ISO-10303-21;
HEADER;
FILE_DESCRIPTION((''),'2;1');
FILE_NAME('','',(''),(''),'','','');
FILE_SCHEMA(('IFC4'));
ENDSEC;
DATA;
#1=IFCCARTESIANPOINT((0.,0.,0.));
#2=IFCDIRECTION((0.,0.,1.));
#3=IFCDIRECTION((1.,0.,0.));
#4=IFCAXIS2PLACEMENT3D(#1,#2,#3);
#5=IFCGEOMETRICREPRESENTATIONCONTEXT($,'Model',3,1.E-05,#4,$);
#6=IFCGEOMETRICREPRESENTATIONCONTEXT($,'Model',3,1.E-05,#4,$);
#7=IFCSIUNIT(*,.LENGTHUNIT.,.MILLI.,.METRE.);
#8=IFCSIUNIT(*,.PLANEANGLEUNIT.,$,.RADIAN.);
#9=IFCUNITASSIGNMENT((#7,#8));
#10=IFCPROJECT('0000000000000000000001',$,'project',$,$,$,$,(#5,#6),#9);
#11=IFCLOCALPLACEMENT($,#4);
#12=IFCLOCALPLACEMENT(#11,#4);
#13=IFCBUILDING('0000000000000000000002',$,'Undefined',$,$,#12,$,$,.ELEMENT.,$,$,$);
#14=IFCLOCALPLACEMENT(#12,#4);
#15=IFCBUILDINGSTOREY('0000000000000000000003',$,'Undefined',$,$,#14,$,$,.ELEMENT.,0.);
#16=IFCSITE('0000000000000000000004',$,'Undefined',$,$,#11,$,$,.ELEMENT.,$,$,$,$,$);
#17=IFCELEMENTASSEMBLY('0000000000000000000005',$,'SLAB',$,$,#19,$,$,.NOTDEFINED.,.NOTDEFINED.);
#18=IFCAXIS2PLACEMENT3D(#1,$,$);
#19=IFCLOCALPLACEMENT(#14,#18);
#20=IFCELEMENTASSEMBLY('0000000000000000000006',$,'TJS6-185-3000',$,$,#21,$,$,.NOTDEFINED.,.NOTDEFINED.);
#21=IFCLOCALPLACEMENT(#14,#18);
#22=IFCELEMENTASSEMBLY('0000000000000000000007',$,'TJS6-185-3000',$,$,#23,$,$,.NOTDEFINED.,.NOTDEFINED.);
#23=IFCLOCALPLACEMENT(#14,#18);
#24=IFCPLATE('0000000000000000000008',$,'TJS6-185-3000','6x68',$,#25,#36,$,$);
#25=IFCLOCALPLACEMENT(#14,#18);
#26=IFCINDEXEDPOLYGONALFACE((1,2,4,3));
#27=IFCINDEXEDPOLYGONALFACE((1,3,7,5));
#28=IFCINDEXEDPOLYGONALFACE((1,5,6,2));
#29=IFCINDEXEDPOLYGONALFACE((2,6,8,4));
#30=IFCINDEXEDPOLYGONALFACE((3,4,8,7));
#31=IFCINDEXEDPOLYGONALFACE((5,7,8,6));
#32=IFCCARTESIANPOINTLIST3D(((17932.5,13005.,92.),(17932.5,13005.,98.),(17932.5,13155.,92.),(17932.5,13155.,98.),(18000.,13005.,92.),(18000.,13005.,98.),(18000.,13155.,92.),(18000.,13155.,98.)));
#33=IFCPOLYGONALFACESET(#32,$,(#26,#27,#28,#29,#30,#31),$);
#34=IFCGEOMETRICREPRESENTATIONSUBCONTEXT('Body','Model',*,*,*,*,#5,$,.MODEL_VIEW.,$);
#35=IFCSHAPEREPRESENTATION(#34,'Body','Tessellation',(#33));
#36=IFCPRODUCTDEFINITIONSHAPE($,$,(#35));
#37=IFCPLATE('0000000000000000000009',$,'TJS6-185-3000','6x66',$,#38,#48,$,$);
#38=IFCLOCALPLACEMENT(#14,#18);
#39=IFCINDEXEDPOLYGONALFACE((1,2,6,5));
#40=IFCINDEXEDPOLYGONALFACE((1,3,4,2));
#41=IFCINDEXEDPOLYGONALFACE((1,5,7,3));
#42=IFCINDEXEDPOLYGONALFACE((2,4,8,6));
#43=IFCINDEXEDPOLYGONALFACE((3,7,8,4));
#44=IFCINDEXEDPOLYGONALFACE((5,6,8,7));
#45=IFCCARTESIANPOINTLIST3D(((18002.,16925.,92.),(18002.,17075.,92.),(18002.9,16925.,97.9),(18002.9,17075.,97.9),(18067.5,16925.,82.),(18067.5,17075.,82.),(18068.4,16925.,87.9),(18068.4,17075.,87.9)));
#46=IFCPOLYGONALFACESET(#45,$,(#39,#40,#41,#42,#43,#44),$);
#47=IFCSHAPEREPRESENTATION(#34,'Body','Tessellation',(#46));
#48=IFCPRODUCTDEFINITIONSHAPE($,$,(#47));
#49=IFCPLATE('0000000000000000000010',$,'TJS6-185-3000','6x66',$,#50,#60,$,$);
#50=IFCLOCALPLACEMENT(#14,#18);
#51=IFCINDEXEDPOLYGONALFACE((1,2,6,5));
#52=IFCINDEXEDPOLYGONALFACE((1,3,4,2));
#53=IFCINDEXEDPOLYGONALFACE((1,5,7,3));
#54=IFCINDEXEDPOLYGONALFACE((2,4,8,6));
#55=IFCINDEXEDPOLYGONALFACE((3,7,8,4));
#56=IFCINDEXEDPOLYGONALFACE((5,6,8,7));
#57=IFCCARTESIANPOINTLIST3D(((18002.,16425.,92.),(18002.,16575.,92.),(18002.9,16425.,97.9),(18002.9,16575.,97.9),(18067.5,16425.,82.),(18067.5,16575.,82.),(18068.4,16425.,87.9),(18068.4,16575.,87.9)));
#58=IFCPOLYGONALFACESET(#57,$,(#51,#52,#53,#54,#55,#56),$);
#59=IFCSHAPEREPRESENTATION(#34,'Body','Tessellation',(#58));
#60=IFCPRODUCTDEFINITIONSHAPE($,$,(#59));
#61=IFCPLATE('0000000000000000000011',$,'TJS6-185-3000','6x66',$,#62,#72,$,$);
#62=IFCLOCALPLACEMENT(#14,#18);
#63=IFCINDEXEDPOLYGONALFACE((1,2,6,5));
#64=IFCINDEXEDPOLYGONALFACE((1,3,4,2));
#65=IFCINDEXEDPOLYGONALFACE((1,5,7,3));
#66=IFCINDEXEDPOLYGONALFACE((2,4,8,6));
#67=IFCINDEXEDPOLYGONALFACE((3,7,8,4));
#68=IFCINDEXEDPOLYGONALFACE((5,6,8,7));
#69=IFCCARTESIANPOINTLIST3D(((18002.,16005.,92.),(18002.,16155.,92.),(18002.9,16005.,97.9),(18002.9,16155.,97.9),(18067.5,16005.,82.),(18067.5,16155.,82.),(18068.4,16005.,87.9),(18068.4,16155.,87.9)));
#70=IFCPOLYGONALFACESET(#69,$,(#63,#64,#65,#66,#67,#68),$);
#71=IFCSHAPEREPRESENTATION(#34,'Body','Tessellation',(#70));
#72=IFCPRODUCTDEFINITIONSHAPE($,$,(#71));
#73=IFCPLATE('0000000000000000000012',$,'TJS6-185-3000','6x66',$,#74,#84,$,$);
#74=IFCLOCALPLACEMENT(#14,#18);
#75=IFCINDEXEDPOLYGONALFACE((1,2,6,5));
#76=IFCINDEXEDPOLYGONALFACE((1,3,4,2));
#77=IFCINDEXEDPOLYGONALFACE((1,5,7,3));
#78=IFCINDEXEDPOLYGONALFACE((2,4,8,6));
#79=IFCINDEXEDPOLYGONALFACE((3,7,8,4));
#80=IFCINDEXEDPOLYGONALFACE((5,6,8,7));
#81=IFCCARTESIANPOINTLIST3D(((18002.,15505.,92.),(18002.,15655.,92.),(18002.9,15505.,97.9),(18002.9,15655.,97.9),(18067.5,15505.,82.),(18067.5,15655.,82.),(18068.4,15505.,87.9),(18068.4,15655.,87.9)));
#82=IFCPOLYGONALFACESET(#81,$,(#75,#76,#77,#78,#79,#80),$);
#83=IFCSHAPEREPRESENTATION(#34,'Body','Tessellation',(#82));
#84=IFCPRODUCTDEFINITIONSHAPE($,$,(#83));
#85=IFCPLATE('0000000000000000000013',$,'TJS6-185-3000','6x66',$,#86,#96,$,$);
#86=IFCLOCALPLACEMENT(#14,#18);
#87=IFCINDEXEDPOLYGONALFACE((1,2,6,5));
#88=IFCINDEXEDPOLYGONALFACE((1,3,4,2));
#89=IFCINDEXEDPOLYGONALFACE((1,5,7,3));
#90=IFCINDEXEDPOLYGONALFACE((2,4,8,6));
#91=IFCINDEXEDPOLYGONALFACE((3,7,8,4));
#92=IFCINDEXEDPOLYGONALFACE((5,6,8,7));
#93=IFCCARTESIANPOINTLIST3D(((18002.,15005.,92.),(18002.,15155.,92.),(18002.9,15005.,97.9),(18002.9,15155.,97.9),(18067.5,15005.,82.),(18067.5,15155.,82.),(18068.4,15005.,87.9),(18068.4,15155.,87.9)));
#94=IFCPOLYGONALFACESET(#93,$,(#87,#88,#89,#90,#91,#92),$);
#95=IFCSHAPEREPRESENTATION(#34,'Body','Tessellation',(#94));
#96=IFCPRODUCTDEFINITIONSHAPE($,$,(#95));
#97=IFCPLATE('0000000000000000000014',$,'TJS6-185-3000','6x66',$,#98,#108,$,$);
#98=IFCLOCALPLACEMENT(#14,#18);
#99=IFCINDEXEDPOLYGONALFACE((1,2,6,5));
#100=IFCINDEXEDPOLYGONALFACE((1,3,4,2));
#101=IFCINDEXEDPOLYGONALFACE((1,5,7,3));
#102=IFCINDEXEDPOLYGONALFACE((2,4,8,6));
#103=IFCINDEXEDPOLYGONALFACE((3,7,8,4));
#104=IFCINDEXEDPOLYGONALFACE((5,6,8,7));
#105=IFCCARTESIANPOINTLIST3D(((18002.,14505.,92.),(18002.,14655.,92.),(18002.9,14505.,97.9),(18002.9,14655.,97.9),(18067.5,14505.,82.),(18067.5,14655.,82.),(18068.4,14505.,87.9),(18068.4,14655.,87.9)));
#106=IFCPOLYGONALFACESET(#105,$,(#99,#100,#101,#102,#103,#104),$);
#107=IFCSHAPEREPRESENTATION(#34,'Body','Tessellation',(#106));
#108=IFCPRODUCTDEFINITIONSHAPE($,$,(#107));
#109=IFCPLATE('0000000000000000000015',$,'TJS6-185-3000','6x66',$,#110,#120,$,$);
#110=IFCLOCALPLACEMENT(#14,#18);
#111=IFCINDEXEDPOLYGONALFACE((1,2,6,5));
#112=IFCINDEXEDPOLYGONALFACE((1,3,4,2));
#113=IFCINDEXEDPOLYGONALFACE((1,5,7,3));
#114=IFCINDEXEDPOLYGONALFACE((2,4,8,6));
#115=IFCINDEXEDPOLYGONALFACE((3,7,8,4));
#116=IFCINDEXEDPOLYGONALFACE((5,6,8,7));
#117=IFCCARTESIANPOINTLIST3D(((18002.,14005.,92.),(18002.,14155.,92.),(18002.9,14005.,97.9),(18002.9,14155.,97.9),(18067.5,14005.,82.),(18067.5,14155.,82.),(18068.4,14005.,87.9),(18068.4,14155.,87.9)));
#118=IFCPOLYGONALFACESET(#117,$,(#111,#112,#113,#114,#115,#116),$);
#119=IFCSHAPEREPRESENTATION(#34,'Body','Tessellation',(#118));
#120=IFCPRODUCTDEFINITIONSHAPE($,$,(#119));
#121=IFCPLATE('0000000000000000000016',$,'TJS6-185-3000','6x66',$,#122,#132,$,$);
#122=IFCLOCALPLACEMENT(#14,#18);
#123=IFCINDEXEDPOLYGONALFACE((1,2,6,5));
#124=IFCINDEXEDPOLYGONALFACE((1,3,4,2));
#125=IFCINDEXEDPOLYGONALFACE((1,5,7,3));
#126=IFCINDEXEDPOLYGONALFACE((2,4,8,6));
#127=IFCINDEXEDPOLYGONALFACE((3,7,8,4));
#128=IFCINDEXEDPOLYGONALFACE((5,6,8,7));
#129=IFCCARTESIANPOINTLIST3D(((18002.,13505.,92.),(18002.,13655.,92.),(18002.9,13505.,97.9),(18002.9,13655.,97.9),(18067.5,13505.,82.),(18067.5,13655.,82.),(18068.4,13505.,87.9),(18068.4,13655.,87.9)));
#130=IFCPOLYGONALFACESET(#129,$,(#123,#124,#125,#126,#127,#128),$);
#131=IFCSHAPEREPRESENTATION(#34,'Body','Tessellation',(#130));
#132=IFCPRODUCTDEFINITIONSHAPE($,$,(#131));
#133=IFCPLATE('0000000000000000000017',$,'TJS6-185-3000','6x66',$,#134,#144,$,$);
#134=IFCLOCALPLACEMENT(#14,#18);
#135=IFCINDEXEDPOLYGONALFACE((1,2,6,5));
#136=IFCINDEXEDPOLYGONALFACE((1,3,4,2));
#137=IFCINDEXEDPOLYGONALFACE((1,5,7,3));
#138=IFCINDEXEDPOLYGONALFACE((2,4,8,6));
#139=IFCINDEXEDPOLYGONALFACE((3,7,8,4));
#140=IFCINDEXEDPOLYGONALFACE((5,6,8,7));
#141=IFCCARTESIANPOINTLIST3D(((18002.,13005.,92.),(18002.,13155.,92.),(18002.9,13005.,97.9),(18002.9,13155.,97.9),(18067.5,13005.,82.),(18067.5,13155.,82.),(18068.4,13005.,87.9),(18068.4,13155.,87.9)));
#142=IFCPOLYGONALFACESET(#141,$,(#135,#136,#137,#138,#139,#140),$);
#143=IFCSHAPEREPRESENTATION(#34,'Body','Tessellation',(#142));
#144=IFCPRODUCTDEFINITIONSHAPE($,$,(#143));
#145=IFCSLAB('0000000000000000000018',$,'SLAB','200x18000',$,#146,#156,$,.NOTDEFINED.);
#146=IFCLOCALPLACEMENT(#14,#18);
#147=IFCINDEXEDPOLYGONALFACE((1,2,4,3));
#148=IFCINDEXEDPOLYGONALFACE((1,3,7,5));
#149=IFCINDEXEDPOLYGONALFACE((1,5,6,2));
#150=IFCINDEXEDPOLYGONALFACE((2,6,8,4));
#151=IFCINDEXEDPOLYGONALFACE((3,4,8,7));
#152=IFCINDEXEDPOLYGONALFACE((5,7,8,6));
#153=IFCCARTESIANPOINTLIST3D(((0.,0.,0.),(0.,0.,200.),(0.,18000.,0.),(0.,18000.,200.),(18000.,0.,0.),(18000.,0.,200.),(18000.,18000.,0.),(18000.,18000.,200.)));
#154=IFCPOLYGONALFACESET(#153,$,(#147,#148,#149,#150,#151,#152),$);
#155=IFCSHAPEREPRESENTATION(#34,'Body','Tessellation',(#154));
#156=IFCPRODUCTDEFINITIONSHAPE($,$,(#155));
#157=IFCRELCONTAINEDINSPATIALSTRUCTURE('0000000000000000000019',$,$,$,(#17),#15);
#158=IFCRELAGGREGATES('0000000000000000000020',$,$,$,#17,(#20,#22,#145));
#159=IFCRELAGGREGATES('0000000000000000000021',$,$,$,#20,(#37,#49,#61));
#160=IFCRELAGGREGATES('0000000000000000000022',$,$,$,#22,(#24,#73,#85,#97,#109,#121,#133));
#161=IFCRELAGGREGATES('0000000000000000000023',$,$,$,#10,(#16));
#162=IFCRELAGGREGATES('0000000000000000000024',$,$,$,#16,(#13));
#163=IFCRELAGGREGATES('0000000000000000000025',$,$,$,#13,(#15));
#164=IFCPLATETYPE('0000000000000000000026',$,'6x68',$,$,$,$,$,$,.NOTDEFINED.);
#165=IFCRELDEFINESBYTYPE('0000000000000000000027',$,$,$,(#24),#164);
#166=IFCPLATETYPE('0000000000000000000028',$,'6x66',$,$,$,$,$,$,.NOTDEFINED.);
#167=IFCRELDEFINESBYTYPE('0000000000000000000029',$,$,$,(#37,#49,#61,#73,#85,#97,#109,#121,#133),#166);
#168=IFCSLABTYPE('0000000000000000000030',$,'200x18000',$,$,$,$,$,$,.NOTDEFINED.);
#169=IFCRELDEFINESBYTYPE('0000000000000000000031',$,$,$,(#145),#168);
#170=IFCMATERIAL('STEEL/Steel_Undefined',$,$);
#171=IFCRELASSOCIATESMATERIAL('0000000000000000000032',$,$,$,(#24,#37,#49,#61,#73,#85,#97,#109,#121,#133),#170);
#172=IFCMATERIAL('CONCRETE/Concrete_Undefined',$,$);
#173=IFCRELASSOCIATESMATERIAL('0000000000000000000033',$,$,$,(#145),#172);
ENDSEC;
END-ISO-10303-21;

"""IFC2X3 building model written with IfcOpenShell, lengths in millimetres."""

from ifc_helpers import new_model, si_unit, frame, origin_with_axes, place, context, subcontext, project, spatial, polyline, outline, extrude, material, type_object, element, aggregate, save


model = new_model("IFC2X3")

# Units and contexts
model_context_1 = context("Model", 3, precision=1e-05, world=origin_with_axes())
model_context_2 = context("Model", 3, precision=1e-05, world=origin_with_axes())
body_context = subcontext(model_context_1, "Body", "Model", "MODEL_VIEW")
ifc_project = project(units=[si_unit("LENGTHUNIT", "METRE", prefix="MILLI"), si_unit("PLANEANGLEUNIT", "RADIAN")], contexts=[model_context_1, model_context_2])

# Site, building, storey
site_placement = place(None, origin_with_axes())
site = spatial("IfcSite", under=ifc_project, at=site_placement, Name="Undefined", CompositionType="ELEMENT")
building_placement = place(site_placement, origin_with_axes())
building = spatial("IfcBuilding", under=site, at=building_placement, Name="Undefined", CompositionType="ELEMENT")
storey_placement = place(building_placement, origin_with_axes())
storey = spatial("IfcBuildingStorey", under=building, at=storey_placement, Name="Undefined", CompositionType="ELEMENT", Elevation=0.0)

# Shared definitions
ifc_material_1 = material(Name="CONCRETE/Concrete_Undefined")

# Element assemblies, plates, slab
assembly_1_placement = place(storey_placement, origin_with_axes())
assembly_1 = element("IfcElementAssembly", 1, at=assembly_1_placement, inside=storey, Name="SLAB", AssemblyPlace="NOTDEFINED", PredefinedType="NOTDEFINED")
assembly_2_placement = place(assembly_1_placement, origin_with_axes())
assembly_2 = element("IfcElementAssembly", 2, at=assembly_2_placement, Name="TJS6-185-3000", AssemblyPlace="NOTDEFINED", PredefinedType="NOTDEFINED")
ifc_material_2 = material(Name="STEEL/Steel_Undefined")
assembly_3_placement = place(assembly_1_placement, origin_with_axes())
assembly_3 = element("IfcElementAssembly", 3, at=assembly_3_placement, Name="TJS6-185-3000", AssemblyPlace="NOTDEFINED", PredefinedType="NOTDEFINED")
plate_type_1 = type_object("IfcPlateType", Name="6x68", PredefinedType="NOTDEFINED")
plate_1_placement = place(assembly_3_placement, frame((18000.0, 13005.0, 95.0), z_axis=(0.0, 0.0, 1.0), x_axis=(0.0, 1.0, 0.0)))
plate_1 = element("IfcPlate", 4, at=plate_1_placement, type_object=plate_type_1, material=ifc_material_2, Name="TJS6-185-3000", Description="6x68", context=body_context, shape_type="SweptSolid", body=[
    extrude(outline(polyline([(0.0, 0.0), (150.0, 0.0), (150.0, 67.5), (0.0, 67.5), (0.0, 0.0)])), frame((0.0, 0.0, -3.0), z_axis=(0.0, 0.0, 1.0), x_axis=(1.0, 0.0, 0.0)), (0.0, 0.0, 1.0), 6.0),
])
plate_type_2 = type_object("IfcPlateType", Name="6x66", PredefinedType="NOTDEFINED")
plate_2_placement = place(assembly_2_placement, frame((18002.5, 16925.0, 95.0), z_axis=(-0.150923, 0.0, -0.988546), x_axis=(0.0, 1.0, 0.0)))
plate_2 = element("IfcPlate", 5, at=plate_2_placement, type_object=plate_type_2, material=ifc_material_2, Name="TJS6-185-3000", Description="6x66", context=body_context, shape_type="SweptSolid", body=[
    extrude(outline(polyline([(0.0, 0.0), (150.0, 0.0), (150.0, 66.3), (0.0, 66.3), (0.0, 0.0)])), frame((0.0, 0.0, -3.0), z_axis=(0.0, 0.0, 1.0), x_axis=(1.0, 0.0, 0.0)), (0.0, 0.0, 1.0), 6.0),
])
plate_3_placement = place(assembly_2_placement, frame((18002.5, 16425.0, 95.0), z_axis=(-0.150923, 0.0, -0.988546), x_axis=(0.0, 1.0, 0.0)))
plate_3 = element("IfcPlate", 6, at=plate_3_placement, type_object=plate_type_2, material=ifc_material_2, Name="TJS6-185-3000", Description="6x66", context=body_context, shape_type="SweptSolid", body=[
    extrude(outline(polyline([(0.0, 0.0), (150.0, 0.0), (150.0, 66.3), (0.0, 66.3), (0.0, 0.0)])), frame((0.0, 0.0, -3.0), z_axis=(0.0, 0.0, 1.0), x_axis=(1.0, 0.0, 0.0)), (0.0, 0.0, 1.0), 6.0),
])
plate_4_placement = place(assembly_2_placement, frame((18002.5, 16005.0, 95.0), z_axis=(-0.150923, 0.0, -0.988546), x_axis=(0.0, 1.0, 0.0)))
plate_4 = element("IfcPlate", 7, at=plate_4_placement, type_object=plate_type_2, material=ifc_material_2, Name="TJS6-185-3000", Description="6x66", context=body_context, shape_type="SweptSolid", body=[
    extrude(outline(polyline([(0.0, 0.0), (150.0, 0.0), (150.0, 66.3), (0.0, 66.3), (0.0, 0.0)])), frame((0.0, 0.0, -3.0), z_axis=(0.0, 0.0, 1.0), x_axis=(1.0, 0.0, 0.0)), (0.0, 0.0, 1.0), 6.0),
])
plate_5_placement = place(assembly_3_placement, frame((18002.5, 15505.0, 95.0), z_axis=(-0.150923, 0.0, -0.988546), x_axis=(0.0, 1.0, 0.0)))
plate_5 = element("IfcPlate", 8, at=plate_5_placement, type_object=plate_type_2, material=ifc_material_2, Name="TJS6-185-3000", Description="6x66", context=body_context, shape_type="SweptSolid", body=[
    extrude(outline(polyline([(0.0, 0.0), (150.0, 0.0), (150.0, 66.3), (0.0, 66.3), (0.0, 0.0)])), frame((0.0, 0.0, -3.0), z_axis=(0.0, 0.0, 1.0), x_axis=(1.0, 0.0, 0.0)), (0.0, 0.0, 1.0), 6.0),
])
plate_6_placement = place(assembly_3_placement, frame((18002.5, 15005.0, 95.0), z_axis=(-0.150923, 0.0, -0.988546), x_axis=(0.0, 1.0, 0.0)))
plate_6 = element("IfcPlate", 9, at=plate_6_placement, type_object=plate_type_2, material=ifc_material_2, Name="TJS6-185-3000", Description="6x66", context=body_context, shape_type="SweptSolid", body=[
    extrude(outline(polyline([(0.0, 0.0), (150.0, 0.0), (150.0, 66.3), (0.0, 66.3), (0.0, 0.0)])), frame((0.0, 0.0, -3.0), z_axis=(0.0, 0.0, 1.0), x_axis=(1.0, 0.0, 0.0)), (0.0, 0.0, 1.0), 6.0),
])
plate_7_placement = place(assembly_3_placement, frame((18002.5, 14505.0, 95.0), z_axis=(-0.150923, 0.0, -0.988546), x_axis=(0.0, 1.0, 0.0)))
plate_7 = element("IfcPlate", 10, at=plate_7_placement, type_object=plate_type_2, material=ifc_material_2, Name="TJS6-185-3000", Description="6x66", context=body_context, shape_type="SweptSolid", body=[
    extrude(outline(polyline([(0.0, 0.0), (150.0, 0.0), (150.0, 66.3), (0.0, 66.3), (0.0, 0.0)])), frame((0.0, 0.0, -3.0), z_axis=(0.0, 0.0, 1.0), x_axis=(1.0, 0.0, 0.0)), (0.0, 0.0, 1.0), 6.0),
])
plate_8_placement = place(assembly_3_placement, frame((18002.5, 14005.0, 95.0), z_axis=(-0.150923, 0.0, -0.988546), x_axis=(0.0, 1.0, 0.0)))
plate_8 = element("IfcPlate", 11, at=plate_8_placement, type_object=plate_type_2, material=ifc_material_2, Name="TJS6-185-3000", Description="6x66", context=body_context, shape_type="SweptSolid", body=[
    extrude(outline(polyline([(0.0, 0.0), (150.0, 0.0), (150.0, 66.3), (0.0, 66.3), (0.0, 0.0)])), frame((0.0, 0.0, -3.0), z_axis=(0.0, 0.0, 1.0), x_axis=(1.0, 0.0, 0.0)), (0.0, 0.0, 1.0), 6.0),
])
plate_9_placement = place(assembly_3_placement, frame((18002.5, 13505.0, 95.0), z_axis=(-0.150923, 0.0, -0.988546), x_axis=(0.0, 1.0, 0.0)))
plate_9 = element("IfcPlate", 12, at=plate_9_placement, type_object=plate_type_2, material=ifc_material_2, Name="TJS6-185-3000", Description="6x66", context=body_context, shape_type="SweptSolid", body=[
    extrude(outline(polyline([(0.0, 0.0), (150.0, 0.0), (150.0, 66.3), (0.0, 66.3), (0.0, 0.0)])), frame((0.0, 0.0, -3.0), z_axis=(0.0, 0.0, 1.0), x_axis=(1.0, 0.0, 0.0)), (0.0, 0.0, 1.0), 6.0),
])
plate_10_placement = place(assembly_3_placement, frame((18002.5, 13005.0, 95.0), z_axis=(-0.150923, 0.0, -0.988546), x_axis=(0.0, 1.0, 0.0)))
plate_10 = element("IfcPlate", 13, at=plate_10_placement, type_object=plate_type_2, material=ifc_material_2, Name="TJS6-185-3000", Description="6x66", context=body_context, shape_type="SweptSolid", body=[
    extrude(outline(polyline([(0.0, 0.0), (150.0, 0.0), (150.0, 66.3), (0.0, 66.3), (0.0, 0.0)])), frame((0.0, 0.0, -3.0), z_axis=(0.0, 0.0, 1.0), x_axis=(1.0, 0.0, 0.0)), (0.0, 0.0, 1.0), 6.0),
])
slab_type = type_object("IfcSlabType", Name="200x18000", PredefinedType="NOTDEFINED")
slab_placement = place(assembly_1_placement, frame((18000.0, 18000.0, 100.0), z_axis=(0.0, 0.0, 1.0), x_axis=(-1.0, 0.0, 0.0)))
slab = element("IfcSlab", 14, at=slab_placement, type_object=slab_type, material=ifc_material_1, Name="SLAB", Description="200x18000", PredefinedType="NOTDEFINED", context=body_context, shape_type="SweptSolid", body=[
    extrude(outline(polyline([(0.0, 0.0), (18000.0, 0.0), (18000.0, 18000.0), (0.0, 18000.0), (0.0, 0.0)])), frame((0.0, 0.0, -100.0), z_axis=(0.0, 0.0, 1.0), x_axis=(1.0, 0.0, 0.0)), (0.0, 0.0, 1.0), 200.0),
])
aggregate(assembly_1, [assembly_2, assembly_3, slab])

aggregate(assembly_2, [plate_2, plate_3, plate_4])
aggregate(assembly_3, [plate_1, plate_5, plate_6, plate_7, plate_8, plate_9, plate_10])

save(model, "model.ifc")
